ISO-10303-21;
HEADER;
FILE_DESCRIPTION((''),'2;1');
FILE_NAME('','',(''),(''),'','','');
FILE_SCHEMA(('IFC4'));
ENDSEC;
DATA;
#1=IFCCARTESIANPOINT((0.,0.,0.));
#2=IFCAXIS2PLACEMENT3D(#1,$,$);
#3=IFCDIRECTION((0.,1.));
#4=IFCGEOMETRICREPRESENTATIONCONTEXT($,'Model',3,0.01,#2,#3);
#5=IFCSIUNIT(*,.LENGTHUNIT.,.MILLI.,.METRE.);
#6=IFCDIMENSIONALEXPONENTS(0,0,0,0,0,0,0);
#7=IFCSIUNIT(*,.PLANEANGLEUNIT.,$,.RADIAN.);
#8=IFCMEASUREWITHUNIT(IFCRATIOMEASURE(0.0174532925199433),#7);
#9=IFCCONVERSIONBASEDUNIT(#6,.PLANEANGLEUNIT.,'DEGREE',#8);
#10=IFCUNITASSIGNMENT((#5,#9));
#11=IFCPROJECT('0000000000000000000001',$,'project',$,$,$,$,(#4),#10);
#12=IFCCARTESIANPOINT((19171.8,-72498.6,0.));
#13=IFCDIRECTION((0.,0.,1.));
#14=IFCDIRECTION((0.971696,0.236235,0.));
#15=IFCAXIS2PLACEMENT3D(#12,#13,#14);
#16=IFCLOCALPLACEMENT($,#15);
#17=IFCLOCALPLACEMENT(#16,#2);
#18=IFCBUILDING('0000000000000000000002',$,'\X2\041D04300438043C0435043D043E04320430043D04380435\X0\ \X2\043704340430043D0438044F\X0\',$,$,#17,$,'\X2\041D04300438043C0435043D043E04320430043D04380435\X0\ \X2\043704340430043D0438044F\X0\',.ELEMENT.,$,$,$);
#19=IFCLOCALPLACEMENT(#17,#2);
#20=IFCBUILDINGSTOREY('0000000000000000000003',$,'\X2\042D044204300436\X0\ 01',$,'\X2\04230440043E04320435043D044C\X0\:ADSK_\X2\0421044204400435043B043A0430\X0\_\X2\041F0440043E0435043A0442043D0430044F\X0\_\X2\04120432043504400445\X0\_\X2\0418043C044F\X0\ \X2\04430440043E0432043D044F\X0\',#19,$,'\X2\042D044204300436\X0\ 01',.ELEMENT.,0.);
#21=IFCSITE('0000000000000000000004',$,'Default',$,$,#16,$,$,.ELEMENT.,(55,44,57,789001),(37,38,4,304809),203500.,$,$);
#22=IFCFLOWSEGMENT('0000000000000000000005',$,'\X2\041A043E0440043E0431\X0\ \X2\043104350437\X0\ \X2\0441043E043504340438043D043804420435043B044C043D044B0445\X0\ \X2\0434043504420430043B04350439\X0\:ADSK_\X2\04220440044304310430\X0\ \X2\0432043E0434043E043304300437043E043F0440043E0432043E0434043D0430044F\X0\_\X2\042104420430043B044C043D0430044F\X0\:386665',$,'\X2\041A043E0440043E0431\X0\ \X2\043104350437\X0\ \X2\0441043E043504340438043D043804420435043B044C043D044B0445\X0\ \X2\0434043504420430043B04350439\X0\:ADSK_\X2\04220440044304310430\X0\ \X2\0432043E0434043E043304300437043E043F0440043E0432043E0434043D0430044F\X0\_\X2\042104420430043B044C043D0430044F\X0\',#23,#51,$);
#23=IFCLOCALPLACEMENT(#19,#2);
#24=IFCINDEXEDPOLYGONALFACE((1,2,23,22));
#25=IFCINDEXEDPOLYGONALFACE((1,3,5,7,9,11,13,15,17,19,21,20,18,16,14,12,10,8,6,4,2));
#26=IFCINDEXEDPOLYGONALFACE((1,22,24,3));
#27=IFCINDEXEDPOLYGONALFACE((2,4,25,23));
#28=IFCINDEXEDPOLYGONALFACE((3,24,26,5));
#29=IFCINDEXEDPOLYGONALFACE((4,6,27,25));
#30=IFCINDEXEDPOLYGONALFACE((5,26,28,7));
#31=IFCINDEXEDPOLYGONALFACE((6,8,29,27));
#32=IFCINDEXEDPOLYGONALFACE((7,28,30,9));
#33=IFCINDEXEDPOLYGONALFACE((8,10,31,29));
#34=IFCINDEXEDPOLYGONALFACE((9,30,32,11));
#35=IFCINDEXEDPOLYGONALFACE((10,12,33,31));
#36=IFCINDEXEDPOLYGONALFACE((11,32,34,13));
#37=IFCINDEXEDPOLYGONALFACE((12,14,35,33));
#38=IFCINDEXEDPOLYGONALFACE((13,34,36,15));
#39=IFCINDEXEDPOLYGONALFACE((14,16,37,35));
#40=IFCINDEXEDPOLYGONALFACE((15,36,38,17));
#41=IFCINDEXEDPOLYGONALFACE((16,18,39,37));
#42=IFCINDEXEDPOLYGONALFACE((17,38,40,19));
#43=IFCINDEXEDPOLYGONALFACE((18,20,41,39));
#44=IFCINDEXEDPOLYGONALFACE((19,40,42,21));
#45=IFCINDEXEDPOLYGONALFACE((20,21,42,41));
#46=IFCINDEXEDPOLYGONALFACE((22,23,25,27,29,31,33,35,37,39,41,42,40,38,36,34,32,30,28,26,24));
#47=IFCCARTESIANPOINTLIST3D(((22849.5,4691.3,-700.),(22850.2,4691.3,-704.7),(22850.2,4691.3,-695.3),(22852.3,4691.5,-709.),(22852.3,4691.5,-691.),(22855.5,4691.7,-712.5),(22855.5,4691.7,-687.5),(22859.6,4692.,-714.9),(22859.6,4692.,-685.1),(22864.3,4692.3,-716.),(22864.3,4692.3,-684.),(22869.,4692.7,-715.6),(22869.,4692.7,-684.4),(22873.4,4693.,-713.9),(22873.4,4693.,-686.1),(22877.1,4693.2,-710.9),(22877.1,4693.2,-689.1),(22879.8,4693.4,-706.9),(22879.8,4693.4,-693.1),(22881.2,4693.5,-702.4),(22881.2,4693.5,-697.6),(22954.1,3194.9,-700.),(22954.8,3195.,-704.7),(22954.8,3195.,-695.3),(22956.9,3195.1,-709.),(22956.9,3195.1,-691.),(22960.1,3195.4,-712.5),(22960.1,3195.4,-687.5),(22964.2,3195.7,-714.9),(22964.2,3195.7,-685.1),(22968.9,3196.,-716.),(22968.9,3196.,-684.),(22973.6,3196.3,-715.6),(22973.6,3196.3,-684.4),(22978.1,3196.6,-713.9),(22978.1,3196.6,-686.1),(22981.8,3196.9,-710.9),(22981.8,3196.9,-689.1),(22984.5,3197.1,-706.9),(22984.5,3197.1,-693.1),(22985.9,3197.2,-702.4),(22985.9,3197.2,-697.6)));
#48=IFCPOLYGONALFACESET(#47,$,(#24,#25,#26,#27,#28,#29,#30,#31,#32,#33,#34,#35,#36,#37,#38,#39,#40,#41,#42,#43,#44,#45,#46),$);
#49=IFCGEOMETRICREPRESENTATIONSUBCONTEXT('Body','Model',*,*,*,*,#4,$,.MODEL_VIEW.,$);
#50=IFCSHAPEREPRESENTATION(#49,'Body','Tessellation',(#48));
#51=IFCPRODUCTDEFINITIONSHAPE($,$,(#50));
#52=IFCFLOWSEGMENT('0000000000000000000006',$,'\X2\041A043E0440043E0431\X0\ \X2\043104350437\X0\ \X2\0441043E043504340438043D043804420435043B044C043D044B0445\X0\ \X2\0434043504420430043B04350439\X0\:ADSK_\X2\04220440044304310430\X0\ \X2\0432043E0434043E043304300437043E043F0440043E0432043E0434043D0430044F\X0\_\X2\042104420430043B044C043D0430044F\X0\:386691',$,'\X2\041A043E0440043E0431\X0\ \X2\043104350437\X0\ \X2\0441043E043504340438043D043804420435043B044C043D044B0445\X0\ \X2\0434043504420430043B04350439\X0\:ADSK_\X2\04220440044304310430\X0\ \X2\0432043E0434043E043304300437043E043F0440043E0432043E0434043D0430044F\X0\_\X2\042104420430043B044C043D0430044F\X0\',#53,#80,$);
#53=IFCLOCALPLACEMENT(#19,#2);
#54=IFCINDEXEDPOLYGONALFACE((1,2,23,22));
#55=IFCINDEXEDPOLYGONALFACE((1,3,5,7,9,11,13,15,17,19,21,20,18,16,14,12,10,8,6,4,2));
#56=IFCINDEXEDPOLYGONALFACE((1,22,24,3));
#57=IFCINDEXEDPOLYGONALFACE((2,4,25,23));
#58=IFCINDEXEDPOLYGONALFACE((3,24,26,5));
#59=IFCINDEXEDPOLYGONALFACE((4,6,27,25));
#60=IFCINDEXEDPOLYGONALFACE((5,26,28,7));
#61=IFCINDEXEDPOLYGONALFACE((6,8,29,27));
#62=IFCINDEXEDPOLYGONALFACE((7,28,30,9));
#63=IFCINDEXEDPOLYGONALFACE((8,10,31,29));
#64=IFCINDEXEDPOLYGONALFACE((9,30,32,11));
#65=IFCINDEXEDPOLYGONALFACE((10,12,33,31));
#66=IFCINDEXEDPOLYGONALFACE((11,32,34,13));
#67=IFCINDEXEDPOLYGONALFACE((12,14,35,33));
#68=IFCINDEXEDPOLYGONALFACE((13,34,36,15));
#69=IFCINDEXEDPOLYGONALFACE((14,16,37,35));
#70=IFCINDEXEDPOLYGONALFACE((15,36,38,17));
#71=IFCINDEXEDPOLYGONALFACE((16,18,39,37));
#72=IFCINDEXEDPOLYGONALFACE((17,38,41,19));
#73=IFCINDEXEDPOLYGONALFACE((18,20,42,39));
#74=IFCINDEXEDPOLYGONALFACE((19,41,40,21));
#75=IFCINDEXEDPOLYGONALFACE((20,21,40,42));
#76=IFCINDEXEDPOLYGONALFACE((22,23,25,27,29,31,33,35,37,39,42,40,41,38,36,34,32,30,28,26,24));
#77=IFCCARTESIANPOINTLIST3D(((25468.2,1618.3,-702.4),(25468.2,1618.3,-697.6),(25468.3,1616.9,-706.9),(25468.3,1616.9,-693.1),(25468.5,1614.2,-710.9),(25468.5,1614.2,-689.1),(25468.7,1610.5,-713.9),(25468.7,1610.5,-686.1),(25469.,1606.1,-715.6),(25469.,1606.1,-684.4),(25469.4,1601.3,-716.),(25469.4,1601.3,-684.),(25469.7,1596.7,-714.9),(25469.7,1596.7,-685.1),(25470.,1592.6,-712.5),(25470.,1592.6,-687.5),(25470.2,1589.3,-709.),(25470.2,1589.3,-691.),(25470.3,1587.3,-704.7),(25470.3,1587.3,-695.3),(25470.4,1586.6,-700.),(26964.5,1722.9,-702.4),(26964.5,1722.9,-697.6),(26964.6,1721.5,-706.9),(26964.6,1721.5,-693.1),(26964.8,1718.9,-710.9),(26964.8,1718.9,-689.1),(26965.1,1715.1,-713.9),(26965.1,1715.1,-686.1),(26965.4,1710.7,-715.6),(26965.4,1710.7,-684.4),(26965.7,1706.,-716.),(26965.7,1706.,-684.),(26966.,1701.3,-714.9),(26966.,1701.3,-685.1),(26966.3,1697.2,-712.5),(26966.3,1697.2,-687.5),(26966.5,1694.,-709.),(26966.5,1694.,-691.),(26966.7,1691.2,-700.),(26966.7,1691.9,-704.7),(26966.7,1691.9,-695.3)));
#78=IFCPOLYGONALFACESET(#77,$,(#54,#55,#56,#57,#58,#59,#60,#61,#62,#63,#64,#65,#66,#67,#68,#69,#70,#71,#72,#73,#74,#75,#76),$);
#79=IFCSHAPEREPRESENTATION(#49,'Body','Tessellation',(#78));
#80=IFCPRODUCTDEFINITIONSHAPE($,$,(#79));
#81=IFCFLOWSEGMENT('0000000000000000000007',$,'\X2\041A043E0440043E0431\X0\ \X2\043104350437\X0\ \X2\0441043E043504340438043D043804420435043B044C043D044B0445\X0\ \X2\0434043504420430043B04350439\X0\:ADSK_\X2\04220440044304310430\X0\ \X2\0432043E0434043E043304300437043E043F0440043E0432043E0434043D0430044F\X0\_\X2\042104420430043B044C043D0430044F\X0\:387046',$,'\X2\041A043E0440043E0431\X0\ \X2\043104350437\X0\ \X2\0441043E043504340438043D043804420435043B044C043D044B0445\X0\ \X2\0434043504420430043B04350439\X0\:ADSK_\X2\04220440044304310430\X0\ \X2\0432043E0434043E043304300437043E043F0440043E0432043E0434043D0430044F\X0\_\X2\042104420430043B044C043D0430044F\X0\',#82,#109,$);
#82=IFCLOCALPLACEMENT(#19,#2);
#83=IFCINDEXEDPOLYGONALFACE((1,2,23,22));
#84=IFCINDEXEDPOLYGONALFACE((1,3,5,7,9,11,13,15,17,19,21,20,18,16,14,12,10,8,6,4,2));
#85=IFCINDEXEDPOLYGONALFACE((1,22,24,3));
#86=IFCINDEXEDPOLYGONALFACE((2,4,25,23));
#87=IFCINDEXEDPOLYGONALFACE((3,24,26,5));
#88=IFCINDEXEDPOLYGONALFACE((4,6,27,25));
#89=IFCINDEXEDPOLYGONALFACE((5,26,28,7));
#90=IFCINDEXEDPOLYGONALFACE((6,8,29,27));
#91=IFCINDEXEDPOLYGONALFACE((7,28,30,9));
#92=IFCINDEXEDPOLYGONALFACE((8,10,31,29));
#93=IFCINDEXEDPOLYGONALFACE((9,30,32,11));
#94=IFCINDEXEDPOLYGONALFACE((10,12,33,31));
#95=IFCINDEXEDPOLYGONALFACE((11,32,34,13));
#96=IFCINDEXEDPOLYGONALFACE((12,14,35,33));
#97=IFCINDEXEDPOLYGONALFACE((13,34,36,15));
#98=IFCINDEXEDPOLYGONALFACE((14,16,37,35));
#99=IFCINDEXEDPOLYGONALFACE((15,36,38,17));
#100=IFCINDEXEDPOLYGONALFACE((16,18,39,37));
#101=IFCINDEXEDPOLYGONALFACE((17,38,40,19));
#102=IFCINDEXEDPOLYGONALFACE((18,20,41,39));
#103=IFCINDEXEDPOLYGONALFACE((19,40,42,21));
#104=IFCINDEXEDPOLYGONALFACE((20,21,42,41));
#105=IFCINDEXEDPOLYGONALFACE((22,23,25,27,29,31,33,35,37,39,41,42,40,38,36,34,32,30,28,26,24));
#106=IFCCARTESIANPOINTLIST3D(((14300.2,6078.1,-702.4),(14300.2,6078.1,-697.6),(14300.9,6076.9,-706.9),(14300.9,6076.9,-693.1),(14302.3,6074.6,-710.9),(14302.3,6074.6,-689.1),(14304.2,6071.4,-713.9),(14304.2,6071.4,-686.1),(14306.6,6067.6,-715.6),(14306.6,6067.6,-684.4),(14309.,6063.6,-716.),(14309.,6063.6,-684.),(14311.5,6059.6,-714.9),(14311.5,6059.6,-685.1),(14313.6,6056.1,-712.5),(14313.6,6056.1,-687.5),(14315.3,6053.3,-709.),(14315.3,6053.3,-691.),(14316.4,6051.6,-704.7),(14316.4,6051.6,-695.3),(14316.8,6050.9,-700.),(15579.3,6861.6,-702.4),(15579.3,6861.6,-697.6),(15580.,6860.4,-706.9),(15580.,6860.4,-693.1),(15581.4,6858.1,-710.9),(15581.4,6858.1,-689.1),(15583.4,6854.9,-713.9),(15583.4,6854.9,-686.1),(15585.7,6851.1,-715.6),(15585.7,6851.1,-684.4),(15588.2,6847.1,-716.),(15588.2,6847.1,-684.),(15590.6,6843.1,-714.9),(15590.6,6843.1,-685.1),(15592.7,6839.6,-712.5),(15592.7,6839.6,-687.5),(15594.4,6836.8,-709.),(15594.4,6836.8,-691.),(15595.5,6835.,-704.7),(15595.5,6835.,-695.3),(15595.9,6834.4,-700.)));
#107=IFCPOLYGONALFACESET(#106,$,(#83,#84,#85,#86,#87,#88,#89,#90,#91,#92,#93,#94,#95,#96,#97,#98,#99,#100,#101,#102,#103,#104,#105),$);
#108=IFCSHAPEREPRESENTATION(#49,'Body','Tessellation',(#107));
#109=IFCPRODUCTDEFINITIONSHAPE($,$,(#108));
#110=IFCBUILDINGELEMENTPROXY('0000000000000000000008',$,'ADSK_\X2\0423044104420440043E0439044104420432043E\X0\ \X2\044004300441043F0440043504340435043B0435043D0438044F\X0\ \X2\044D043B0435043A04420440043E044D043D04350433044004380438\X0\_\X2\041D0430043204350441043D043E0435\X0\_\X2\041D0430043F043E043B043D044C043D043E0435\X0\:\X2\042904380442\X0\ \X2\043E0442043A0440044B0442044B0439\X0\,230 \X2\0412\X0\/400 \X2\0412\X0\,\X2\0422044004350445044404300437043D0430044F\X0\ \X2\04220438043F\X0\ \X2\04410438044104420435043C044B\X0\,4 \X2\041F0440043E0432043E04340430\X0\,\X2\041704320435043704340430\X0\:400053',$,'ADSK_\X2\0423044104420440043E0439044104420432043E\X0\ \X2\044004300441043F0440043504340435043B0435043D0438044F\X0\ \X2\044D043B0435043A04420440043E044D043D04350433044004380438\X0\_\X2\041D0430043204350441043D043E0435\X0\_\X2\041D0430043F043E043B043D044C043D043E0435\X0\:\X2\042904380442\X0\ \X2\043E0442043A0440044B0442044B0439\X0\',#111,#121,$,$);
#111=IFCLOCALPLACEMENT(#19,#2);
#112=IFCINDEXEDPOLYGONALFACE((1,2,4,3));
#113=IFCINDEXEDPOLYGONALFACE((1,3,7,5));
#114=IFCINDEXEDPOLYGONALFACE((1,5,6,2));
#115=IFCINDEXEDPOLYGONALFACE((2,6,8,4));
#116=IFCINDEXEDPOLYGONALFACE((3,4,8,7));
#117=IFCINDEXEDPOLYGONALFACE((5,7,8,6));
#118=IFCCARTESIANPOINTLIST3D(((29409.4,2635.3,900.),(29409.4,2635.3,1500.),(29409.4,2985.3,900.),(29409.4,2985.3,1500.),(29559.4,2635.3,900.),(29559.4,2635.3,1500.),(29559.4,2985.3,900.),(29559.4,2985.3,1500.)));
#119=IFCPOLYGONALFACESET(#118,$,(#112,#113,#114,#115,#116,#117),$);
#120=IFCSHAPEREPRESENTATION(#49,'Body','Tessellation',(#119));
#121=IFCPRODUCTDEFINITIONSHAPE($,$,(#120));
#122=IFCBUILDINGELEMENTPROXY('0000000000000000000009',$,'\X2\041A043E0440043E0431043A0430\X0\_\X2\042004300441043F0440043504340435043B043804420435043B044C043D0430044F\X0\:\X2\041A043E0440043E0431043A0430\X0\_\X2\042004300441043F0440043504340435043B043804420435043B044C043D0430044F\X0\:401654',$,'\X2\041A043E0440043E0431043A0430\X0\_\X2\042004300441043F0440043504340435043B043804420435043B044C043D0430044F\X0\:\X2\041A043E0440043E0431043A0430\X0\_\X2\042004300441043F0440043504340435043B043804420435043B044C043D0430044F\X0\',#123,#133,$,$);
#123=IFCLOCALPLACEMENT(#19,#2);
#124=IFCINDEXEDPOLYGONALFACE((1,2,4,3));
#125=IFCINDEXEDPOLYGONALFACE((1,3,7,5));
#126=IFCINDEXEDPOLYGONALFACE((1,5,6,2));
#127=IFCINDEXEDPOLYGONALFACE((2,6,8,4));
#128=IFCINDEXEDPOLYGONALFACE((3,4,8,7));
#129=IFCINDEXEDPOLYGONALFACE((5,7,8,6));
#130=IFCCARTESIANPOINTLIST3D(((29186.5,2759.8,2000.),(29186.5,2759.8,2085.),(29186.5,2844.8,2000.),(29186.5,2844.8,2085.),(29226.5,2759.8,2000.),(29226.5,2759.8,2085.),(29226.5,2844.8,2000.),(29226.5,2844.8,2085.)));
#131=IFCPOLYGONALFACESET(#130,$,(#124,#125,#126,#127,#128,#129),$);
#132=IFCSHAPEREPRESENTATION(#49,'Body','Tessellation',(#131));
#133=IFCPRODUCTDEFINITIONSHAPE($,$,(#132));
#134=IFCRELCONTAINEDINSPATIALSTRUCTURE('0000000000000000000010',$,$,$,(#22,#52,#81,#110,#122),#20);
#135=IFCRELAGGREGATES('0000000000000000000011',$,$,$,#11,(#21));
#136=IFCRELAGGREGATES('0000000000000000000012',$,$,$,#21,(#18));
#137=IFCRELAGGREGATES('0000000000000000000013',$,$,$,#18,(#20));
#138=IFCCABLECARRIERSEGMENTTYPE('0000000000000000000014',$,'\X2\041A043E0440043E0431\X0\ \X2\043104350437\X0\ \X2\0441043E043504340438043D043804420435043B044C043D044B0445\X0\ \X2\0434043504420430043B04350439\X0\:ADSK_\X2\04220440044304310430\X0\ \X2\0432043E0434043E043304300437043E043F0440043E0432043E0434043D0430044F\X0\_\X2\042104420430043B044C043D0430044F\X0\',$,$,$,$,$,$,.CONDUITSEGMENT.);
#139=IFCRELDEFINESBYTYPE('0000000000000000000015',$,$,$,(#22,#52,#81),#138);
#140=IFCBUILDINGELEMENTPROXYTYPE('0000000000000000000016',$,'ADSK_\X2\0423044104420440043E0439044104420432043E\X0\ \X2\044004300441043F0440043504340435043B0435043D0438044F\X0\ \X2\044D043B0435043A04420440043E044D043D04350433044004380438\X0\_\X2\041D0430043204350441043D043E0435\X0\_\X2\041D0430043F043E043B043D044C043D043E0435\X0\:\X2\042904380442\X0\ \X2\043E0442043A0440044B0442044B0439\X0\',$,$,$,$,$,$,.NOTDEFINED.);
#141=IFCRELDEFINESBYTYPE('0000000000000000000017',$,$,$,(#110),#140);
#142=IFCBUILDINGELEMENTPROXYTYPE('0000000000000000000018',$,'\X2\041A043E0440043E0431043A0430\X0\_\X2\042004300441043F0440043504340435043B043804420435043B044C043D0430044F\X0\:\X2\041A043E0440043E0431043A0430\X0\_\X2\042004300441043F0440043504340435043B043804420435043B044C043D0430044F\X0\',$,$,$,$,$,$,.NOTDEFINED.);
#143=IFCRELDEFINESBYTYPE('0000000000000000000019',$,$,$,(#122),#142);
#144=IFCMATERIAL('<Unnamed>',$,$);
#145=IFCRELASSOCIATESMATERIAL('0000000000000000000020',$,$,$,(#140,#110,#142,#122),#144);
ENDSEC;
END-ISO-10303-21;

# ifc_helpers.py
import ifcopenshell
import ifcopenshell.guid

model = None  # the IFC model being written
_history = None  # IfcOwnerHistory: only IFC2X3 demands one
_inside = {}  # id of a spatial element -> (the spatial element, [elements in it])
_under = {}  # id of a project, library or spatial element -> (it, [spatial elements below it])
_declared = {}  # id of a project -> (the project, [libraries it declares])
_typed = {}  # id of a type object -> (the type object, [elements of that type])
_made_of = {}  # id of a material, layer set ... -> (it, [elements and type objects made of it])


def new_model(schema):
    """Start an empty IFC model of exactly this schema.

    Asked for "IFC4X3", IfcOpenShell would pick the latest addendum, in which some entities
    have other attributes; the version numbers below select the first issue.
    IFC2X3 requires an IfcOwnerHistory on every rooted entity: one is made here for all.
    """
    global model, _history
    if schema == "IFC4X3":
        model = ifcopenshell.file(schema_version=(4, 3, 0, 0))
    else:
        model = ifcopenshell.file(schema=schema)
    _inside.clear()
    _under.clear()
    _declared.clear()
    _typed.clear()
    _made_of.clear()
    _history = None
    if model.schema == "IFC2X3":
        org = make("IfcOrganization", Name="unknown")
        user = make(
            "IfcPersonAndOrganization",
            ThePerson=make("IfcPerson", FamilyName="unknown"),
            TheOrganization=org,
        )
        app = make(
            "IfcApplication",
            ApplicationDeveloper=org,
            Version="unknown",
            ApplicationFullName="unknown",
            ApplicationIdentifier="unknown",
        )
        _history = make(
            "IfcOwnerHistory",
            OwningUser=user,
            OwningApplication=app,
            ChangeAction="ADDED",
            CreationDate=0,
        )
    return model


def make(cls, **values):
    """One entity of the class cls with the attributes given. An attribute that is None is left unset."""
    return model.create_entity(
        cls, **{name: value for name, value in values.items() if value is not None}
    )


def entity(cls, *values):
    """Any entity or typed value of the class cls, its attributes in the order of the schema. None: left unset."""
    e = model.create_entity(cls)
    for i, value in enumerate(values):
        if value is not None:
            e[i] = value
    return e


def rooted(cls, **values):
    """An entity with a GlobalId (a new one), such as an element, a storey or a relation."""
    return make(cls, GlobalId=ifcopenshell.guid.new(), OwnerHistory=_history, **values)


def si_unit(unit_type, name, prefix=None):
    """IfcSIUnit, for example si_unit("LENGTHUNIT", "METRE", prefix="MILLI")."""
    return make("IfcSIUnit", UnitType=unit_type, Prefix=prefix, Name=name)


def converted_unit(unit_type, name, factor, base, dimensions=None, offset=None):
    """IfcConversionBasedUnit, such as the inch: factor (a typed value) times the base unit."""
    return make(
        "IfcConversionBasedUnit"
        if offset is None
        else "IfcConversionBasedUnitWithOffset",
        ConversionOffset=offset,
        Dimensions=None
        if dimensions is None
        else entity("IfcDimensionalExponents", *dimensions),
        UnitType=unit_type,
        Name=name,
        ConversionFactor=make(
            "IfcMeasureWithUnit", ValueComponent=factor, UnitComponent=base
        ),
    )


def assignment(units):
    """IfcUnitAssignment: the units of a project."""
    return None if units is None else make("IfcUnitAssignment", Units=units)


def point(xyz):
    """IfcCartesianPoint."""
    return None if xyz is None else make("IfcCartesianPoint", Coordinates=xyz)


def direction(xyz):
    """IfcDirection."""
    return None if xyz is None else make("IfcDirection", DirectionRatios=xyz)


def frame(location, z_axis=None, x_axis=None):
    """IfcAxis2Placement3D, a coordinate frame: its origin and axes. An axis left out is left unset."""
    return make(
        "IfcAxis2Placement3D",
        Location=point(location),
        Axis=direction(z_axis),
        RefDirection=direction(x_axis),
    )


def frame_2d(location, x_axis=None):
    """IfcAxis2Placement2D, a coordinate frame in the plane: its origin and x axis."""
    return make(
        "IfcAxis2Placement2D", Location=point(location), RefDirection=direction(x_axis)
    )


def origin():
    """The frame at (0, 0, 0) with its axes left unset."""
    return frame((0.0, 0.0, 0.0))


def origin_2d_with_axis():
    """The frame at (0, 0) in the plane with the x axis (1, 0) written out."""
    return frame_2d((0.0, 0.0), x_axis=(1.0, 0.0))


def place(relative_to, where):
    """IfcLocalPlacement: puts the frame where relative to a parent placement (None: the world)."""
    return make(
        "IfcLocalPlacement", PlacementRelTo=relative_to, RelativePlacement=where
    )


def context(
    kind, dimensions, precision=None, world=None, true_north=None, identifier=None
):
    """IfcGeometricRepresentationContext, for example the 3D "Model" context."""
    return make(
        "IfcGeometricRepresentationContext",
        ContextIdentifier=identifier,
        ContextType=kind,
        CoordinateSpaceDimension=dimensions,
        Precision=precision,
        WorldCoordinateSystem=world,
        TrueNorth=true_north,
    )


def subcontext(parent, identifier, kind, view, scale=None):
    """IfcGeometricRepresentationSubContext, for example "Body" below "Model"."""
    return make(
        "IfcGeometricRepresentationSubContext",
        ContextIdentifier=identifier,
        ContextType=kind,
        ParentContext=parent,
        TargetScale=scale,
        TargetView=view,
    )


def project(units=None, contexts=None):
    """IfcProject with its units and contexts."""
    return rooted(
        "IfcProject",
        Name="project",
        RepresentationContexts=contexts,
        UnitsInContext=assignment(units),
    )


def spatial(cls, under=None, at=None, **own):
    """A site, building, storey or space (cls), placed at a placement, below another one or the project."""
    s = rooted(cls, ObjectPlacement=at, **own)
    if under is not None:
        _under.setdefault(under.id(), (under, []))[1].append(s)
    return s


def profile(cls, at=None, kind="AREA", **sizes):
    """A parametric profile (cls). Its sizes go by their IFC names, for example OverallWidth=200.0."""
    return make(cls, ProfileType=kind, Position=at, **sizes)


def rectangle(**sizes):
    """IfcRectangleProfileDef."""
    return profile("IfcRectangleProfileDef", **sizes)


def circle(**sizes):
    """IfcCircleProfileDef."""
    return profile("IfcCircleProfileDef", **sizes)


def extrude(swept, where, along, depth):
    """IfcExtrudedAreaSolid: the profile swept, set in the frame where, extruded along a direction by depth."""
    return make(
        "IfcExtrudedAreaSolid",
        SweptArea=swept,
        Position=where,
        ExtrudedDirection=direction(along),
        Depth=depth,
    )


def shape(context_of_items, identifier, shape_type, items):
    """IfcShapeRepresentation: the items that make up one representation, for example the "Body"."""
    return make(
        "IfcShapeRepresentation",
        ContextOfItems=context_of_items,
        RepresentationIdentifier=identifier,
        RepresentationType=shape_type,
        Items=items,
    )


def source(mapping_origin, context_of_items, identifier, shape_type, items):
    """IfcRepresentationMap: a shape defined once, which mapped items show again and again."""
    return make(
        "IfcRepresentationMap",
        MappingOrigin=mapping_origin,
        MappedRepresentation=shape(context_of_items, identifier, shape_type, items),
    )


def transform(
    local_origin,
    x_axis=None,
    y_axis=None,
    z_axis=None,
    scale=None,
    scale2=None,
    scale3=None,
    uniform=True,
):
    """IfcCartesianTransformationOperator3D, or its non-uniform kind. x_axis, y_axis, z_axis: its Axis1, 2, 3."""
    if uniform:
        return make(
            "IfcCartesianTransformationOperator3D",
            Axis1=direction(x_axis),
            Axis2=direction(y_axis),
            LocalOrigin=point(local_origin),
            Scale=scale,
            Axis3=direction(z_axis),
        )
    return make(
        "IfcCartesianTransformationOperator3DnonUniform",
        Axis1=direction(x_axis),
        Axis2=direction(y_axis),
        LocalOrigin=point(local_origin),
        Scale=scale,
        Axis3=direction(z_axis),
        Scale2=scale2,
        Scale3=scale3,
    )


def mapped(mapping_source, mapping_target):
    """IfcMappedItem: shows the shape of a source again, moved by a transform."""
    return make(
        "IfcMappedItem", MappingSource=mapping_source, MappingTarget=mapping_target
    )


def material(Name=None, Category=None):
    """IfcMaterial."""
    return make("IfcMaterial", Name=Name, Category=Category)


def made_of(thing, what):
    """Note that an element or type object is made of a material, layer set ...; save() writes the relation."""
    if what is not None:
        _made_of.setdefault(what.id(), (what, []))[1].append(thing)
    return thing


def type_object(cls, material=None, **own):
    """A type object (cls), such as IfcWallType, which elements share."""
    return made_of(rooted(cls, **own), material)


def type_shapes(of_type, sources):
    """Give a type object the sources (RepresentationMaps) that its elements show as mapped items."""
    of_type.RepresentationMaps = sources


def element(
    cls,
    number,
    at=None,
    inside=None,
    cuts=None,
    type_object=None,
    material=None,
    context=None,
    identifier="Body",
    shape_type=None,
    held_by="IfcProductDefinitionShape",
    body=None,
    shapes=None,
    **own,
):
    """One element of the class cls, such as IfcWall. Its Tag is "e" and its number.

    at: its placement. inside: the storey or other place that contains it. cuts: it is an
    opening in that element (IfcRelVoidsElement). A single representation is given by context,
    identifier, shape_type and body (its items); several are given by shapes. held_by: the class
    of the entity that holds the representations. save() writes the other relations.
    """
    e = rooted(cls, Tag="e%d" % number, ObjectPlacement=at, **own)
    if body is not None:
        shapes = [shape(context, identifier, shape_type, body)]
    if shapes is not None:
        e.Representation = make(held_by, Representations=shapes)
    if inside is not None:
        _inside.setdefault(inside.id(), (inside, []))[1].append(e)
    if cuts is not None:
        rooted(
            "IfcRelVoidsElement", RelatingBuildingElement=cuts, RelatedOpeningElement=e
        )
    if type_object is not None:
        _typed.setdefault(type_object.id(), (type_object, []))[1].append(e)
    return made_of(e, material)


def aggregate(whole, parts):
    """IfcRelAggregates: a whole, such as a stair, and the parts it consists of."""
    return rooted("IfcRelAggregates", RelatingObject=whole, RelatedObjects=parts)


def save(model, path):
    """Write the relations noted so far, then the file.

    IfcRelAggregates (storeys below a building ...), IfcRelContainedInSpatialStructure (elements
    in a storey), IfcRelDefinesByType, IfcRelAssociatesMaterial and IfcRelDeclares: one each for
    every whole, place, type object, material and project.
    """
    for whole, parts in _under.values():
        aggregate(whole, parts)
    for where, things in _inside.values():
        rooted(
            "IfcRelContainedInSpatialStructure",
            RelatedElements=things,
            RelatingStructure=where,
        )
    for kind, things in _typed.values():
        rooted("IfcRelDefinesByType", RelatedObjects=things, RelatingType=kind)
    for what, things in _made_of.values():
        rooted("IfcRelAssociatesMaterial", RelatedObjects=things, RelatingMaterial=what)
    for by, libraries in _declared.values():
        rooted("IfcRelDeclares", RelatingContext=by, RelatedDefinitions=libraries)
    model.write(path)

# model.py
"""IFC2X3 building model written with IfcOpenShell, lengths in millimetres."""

from ifc_helpers import new_model, entity, si_unit, converted_unit, direction, frame, origin, origin_2d_with_axis, place, context, subcontext, project, spatial, rectangle, circle, extrude, source, transform, mapped, material, type_object, type_shapes, element, save


model = new_model("IFC2X3")

# Units and contexts
model_context = context("Model", 3, precision=0.01, world=origin(), true_north=direction((0.0, 1.0)))
body_context = subcontext(model_context, "Body", "Model", "MODEL_VIEW")
ifc_project = project(units=[si_unit("LENGTHUNIT", "METRE", prefix="MILLI"), converted_unit("PLANEANGLEUNIT", "DEGREE", entity("IfcRatioMeasure", 0.0174532925199433), si_unit("PLANEANGLEUNIT", "RADIAN"), dimensions=[0, 0, 0, 0, 0, 0, 0])], contexts=[model_context])

# Site, building, storey
site_placement = place(None, frame((19171.8, -72498.6, 0.0), z_axis=(0.0, 0.0, 1.0), x_axis=(0.971696, 0.236235, 0.0)))
site = spatial("IfcSite", under=ifc_project, at=site_placement, Name="Default", CompositionType="ELEMENT", RefLatitude=(55, 44, 57, 789001), RefLongitude=(37, 38, 4, 304809), RefElevation=203500.0)
building_placement = place(site_placement, origin())
building = spatial("IfcBuilding", under=site, at=building_placement, Name="Наименование здания", LongName="Наименование здания", CompositionType="ELEMENT")
storey_placement = place(building_placement, origin())
storey = spatial("IfcBuildingStorey", under=building, at=storey_placement, Name="Этаж 01", ObjectType="Уровень:ADSK_Стрелка_Проектная_Вверх_Имя уровня", LongName="Этаж 01", CompositionType="ELEMENT", Elevation=0.0)

# Shared definitions
ifc_material = material(Name="<Unnamed>")

# Flow segments
cable_carrier_segment_type_1 = type_object("IfcCableCarrierSegmentType", Name="Короб без соединительных деталей:ADSK_Труба водогазопроводная_Стальная", PredefinedType="CONDUITSEGMENT")
flow_segment_1_placement = place(storey_placement, frame((22847.9, 3193.3, -717.6)))
element("IfcFlowSegment", 1, at=flow_segment_1_placement, inside=storey, type_object=cable_carrier_segment_type_1, Name="Короб без соединительных деталей:ADSK_Труба водогазопроводная_Стальная:386665", ObjectType="Короб без соединительных деталей:ADSK_Труба водогазопроводная_Стальная", context=body_context, shape_type="SweptSolid", body=[
    extrude(circle(Radius=16.0, at=origin_2d_with_axis()), frame((122.2, 2.7, 17.6), z_axis=(-0.069756, 0.997564, 0.0), x_axis=(-0.997564, -0.069756, 0.0)), (0.0, 0.0, 1.0), 1500.0),
])
flow_segment_2_placement = place(storey_placement, frame((25466.6, 1585.0, -717.6)))
element("IfcFlowSegment", 2, at=flow_segment_2_placement, inside=storey, type_object=cable_carrier_segment_type_1, Name="Короб без соединительных деталей:ADSK_Труба водогазопроводная_Стальная:386691", ObjectType="Короб без соединительных деталей:ADSK_Труба водогазопроводная_Стальная", context=body_context, shape_type="SweptSolid", body=[
    extrude(circle(Radius=16.0, at=origin_2d_with_axis()), frame((2.7, 17.6, 17.6), z_axis=(0.997564, 0.069756, 0.0), x_axis=(0.069756, -0.997564, 0.0)), (0.0, 0.0, 1.0), 1500.0),
])
flow_segment_3_placement = place(storey_placement, frame((14298.5, 6049.4, -717.6)))
element("IfcFlowSegment", 3, at=flow_segment_3_placement, inside=storey, type_object=cable_carrier_segment_type_1, Name="Короб без соединительных деталей:ADSK_Труба водогазопроводная_Стальная:387046", ObjectType="Короб без соединительных деталей:ADSK_Труба водогазопроводная_Стальная", context=body_context, shape_type="SweptSolid", body=[
    extrude(circle(Radius=16.0, at=origin_2d_with_axis()), frame((9.9, 15.2, 17.6), z_axis=(0.852745, 0.522328, 0.0), x_axis=(0.522328, -0.852745, 0.0)), (0.0, 0.0, 1.0), 1500.0),
])

# Building element proxies
building_element_proxy_type_1 = type_object("IfcBuildingElementProxyType", Name="ADSK_Устройство распределения электроэнегрии_Навесное_Наполньное:Щит открытый", PredefinedType="NOTDEFINED", material=ifc_material)
shared_shape_1 = source(origin(), body_context, "Body", "SweptSolid", [
    extrude(rectangle(XDim=350.0, YDim=150.0, at=origin_2d_with_axis()), frame((0.0, 75.0, -600.0), z_axis=(0.0, 0.0, 1.0), x_axis=(-1.0, 0.0, 0.0)), (0.0, 0.0, 1.0), 600.0),
])
type_shapes(building_element_proxy_type_1, [shared_shape_1])
proxy_1_placement = place(storey_placement, frame((29559.4, 2810.3, 1500.0), z_axis=(0.0, 0.0, 1.0), x_axis=(0.0, 1.0, 0.0)))
element("IfcBuildingElementProxy", 4, at=proxy_1_placement, inside=storey, type_object=building_element_proxy_type_1, material=ifc_material, Name="ADSK_Устройство распределения электроэнегрии_Навесное_Наполньное:Щит открытый,230 В/400 В,Трехфазная Тип системы,4 Провода,Звезда:400053", ObjectType="ADSK_Устройство распределения электроэнегрии_Навесное_Наполньное:Щит открытый", context=body_context, shape_type="MappedRepresentation", body=[
    mapped(shared_shape_1, transform((0.0, 0.0, 0.0), scale=1.0)),
])
building_element_proxy_type_2 = type_object("IfcBuildingElementProxyType", Name="Коробка_Распределительная:Коробка_Распределительная", PredefinedType="NOTDEFINED", material=ifc_material)
shared_shape_2 = source(origin(), body_context, "Body", "SweptSolid", [
    extrude(rectangle(XDim=85.0, YDim=40.0, at=origin_2d_with_axis()), origin(), (0.0, 0.0, 1.0), 85.0),
])
type_shapes(building_element_proxy_type_2, [shared_shape_2])
proxy_2_placement = place(storey_placement, frame((29206.5, 2802.2, 2000.0), z_axis=(0.0, 0.0, 1.0), x_axis=(0.0, 1.0, 0.0)))
element("IfcBuildingElementProxy", 5, at=proxy_2_placement, inside=storey, type_object=building_element_proxy_type_2, material=ifc_material, Name="Коробка_Распределительная:Коробка_Распределительная:401654", ObjectType="Коробка_Распределительная:Коробка_Распределительная", context=body_context, shape_type="MappedRepresentation", body=[
    mapped(shared_shape_2, transform((0.0, 0.0, 0.0), scale=1.0)),
])

save(model, "model.ifc")
